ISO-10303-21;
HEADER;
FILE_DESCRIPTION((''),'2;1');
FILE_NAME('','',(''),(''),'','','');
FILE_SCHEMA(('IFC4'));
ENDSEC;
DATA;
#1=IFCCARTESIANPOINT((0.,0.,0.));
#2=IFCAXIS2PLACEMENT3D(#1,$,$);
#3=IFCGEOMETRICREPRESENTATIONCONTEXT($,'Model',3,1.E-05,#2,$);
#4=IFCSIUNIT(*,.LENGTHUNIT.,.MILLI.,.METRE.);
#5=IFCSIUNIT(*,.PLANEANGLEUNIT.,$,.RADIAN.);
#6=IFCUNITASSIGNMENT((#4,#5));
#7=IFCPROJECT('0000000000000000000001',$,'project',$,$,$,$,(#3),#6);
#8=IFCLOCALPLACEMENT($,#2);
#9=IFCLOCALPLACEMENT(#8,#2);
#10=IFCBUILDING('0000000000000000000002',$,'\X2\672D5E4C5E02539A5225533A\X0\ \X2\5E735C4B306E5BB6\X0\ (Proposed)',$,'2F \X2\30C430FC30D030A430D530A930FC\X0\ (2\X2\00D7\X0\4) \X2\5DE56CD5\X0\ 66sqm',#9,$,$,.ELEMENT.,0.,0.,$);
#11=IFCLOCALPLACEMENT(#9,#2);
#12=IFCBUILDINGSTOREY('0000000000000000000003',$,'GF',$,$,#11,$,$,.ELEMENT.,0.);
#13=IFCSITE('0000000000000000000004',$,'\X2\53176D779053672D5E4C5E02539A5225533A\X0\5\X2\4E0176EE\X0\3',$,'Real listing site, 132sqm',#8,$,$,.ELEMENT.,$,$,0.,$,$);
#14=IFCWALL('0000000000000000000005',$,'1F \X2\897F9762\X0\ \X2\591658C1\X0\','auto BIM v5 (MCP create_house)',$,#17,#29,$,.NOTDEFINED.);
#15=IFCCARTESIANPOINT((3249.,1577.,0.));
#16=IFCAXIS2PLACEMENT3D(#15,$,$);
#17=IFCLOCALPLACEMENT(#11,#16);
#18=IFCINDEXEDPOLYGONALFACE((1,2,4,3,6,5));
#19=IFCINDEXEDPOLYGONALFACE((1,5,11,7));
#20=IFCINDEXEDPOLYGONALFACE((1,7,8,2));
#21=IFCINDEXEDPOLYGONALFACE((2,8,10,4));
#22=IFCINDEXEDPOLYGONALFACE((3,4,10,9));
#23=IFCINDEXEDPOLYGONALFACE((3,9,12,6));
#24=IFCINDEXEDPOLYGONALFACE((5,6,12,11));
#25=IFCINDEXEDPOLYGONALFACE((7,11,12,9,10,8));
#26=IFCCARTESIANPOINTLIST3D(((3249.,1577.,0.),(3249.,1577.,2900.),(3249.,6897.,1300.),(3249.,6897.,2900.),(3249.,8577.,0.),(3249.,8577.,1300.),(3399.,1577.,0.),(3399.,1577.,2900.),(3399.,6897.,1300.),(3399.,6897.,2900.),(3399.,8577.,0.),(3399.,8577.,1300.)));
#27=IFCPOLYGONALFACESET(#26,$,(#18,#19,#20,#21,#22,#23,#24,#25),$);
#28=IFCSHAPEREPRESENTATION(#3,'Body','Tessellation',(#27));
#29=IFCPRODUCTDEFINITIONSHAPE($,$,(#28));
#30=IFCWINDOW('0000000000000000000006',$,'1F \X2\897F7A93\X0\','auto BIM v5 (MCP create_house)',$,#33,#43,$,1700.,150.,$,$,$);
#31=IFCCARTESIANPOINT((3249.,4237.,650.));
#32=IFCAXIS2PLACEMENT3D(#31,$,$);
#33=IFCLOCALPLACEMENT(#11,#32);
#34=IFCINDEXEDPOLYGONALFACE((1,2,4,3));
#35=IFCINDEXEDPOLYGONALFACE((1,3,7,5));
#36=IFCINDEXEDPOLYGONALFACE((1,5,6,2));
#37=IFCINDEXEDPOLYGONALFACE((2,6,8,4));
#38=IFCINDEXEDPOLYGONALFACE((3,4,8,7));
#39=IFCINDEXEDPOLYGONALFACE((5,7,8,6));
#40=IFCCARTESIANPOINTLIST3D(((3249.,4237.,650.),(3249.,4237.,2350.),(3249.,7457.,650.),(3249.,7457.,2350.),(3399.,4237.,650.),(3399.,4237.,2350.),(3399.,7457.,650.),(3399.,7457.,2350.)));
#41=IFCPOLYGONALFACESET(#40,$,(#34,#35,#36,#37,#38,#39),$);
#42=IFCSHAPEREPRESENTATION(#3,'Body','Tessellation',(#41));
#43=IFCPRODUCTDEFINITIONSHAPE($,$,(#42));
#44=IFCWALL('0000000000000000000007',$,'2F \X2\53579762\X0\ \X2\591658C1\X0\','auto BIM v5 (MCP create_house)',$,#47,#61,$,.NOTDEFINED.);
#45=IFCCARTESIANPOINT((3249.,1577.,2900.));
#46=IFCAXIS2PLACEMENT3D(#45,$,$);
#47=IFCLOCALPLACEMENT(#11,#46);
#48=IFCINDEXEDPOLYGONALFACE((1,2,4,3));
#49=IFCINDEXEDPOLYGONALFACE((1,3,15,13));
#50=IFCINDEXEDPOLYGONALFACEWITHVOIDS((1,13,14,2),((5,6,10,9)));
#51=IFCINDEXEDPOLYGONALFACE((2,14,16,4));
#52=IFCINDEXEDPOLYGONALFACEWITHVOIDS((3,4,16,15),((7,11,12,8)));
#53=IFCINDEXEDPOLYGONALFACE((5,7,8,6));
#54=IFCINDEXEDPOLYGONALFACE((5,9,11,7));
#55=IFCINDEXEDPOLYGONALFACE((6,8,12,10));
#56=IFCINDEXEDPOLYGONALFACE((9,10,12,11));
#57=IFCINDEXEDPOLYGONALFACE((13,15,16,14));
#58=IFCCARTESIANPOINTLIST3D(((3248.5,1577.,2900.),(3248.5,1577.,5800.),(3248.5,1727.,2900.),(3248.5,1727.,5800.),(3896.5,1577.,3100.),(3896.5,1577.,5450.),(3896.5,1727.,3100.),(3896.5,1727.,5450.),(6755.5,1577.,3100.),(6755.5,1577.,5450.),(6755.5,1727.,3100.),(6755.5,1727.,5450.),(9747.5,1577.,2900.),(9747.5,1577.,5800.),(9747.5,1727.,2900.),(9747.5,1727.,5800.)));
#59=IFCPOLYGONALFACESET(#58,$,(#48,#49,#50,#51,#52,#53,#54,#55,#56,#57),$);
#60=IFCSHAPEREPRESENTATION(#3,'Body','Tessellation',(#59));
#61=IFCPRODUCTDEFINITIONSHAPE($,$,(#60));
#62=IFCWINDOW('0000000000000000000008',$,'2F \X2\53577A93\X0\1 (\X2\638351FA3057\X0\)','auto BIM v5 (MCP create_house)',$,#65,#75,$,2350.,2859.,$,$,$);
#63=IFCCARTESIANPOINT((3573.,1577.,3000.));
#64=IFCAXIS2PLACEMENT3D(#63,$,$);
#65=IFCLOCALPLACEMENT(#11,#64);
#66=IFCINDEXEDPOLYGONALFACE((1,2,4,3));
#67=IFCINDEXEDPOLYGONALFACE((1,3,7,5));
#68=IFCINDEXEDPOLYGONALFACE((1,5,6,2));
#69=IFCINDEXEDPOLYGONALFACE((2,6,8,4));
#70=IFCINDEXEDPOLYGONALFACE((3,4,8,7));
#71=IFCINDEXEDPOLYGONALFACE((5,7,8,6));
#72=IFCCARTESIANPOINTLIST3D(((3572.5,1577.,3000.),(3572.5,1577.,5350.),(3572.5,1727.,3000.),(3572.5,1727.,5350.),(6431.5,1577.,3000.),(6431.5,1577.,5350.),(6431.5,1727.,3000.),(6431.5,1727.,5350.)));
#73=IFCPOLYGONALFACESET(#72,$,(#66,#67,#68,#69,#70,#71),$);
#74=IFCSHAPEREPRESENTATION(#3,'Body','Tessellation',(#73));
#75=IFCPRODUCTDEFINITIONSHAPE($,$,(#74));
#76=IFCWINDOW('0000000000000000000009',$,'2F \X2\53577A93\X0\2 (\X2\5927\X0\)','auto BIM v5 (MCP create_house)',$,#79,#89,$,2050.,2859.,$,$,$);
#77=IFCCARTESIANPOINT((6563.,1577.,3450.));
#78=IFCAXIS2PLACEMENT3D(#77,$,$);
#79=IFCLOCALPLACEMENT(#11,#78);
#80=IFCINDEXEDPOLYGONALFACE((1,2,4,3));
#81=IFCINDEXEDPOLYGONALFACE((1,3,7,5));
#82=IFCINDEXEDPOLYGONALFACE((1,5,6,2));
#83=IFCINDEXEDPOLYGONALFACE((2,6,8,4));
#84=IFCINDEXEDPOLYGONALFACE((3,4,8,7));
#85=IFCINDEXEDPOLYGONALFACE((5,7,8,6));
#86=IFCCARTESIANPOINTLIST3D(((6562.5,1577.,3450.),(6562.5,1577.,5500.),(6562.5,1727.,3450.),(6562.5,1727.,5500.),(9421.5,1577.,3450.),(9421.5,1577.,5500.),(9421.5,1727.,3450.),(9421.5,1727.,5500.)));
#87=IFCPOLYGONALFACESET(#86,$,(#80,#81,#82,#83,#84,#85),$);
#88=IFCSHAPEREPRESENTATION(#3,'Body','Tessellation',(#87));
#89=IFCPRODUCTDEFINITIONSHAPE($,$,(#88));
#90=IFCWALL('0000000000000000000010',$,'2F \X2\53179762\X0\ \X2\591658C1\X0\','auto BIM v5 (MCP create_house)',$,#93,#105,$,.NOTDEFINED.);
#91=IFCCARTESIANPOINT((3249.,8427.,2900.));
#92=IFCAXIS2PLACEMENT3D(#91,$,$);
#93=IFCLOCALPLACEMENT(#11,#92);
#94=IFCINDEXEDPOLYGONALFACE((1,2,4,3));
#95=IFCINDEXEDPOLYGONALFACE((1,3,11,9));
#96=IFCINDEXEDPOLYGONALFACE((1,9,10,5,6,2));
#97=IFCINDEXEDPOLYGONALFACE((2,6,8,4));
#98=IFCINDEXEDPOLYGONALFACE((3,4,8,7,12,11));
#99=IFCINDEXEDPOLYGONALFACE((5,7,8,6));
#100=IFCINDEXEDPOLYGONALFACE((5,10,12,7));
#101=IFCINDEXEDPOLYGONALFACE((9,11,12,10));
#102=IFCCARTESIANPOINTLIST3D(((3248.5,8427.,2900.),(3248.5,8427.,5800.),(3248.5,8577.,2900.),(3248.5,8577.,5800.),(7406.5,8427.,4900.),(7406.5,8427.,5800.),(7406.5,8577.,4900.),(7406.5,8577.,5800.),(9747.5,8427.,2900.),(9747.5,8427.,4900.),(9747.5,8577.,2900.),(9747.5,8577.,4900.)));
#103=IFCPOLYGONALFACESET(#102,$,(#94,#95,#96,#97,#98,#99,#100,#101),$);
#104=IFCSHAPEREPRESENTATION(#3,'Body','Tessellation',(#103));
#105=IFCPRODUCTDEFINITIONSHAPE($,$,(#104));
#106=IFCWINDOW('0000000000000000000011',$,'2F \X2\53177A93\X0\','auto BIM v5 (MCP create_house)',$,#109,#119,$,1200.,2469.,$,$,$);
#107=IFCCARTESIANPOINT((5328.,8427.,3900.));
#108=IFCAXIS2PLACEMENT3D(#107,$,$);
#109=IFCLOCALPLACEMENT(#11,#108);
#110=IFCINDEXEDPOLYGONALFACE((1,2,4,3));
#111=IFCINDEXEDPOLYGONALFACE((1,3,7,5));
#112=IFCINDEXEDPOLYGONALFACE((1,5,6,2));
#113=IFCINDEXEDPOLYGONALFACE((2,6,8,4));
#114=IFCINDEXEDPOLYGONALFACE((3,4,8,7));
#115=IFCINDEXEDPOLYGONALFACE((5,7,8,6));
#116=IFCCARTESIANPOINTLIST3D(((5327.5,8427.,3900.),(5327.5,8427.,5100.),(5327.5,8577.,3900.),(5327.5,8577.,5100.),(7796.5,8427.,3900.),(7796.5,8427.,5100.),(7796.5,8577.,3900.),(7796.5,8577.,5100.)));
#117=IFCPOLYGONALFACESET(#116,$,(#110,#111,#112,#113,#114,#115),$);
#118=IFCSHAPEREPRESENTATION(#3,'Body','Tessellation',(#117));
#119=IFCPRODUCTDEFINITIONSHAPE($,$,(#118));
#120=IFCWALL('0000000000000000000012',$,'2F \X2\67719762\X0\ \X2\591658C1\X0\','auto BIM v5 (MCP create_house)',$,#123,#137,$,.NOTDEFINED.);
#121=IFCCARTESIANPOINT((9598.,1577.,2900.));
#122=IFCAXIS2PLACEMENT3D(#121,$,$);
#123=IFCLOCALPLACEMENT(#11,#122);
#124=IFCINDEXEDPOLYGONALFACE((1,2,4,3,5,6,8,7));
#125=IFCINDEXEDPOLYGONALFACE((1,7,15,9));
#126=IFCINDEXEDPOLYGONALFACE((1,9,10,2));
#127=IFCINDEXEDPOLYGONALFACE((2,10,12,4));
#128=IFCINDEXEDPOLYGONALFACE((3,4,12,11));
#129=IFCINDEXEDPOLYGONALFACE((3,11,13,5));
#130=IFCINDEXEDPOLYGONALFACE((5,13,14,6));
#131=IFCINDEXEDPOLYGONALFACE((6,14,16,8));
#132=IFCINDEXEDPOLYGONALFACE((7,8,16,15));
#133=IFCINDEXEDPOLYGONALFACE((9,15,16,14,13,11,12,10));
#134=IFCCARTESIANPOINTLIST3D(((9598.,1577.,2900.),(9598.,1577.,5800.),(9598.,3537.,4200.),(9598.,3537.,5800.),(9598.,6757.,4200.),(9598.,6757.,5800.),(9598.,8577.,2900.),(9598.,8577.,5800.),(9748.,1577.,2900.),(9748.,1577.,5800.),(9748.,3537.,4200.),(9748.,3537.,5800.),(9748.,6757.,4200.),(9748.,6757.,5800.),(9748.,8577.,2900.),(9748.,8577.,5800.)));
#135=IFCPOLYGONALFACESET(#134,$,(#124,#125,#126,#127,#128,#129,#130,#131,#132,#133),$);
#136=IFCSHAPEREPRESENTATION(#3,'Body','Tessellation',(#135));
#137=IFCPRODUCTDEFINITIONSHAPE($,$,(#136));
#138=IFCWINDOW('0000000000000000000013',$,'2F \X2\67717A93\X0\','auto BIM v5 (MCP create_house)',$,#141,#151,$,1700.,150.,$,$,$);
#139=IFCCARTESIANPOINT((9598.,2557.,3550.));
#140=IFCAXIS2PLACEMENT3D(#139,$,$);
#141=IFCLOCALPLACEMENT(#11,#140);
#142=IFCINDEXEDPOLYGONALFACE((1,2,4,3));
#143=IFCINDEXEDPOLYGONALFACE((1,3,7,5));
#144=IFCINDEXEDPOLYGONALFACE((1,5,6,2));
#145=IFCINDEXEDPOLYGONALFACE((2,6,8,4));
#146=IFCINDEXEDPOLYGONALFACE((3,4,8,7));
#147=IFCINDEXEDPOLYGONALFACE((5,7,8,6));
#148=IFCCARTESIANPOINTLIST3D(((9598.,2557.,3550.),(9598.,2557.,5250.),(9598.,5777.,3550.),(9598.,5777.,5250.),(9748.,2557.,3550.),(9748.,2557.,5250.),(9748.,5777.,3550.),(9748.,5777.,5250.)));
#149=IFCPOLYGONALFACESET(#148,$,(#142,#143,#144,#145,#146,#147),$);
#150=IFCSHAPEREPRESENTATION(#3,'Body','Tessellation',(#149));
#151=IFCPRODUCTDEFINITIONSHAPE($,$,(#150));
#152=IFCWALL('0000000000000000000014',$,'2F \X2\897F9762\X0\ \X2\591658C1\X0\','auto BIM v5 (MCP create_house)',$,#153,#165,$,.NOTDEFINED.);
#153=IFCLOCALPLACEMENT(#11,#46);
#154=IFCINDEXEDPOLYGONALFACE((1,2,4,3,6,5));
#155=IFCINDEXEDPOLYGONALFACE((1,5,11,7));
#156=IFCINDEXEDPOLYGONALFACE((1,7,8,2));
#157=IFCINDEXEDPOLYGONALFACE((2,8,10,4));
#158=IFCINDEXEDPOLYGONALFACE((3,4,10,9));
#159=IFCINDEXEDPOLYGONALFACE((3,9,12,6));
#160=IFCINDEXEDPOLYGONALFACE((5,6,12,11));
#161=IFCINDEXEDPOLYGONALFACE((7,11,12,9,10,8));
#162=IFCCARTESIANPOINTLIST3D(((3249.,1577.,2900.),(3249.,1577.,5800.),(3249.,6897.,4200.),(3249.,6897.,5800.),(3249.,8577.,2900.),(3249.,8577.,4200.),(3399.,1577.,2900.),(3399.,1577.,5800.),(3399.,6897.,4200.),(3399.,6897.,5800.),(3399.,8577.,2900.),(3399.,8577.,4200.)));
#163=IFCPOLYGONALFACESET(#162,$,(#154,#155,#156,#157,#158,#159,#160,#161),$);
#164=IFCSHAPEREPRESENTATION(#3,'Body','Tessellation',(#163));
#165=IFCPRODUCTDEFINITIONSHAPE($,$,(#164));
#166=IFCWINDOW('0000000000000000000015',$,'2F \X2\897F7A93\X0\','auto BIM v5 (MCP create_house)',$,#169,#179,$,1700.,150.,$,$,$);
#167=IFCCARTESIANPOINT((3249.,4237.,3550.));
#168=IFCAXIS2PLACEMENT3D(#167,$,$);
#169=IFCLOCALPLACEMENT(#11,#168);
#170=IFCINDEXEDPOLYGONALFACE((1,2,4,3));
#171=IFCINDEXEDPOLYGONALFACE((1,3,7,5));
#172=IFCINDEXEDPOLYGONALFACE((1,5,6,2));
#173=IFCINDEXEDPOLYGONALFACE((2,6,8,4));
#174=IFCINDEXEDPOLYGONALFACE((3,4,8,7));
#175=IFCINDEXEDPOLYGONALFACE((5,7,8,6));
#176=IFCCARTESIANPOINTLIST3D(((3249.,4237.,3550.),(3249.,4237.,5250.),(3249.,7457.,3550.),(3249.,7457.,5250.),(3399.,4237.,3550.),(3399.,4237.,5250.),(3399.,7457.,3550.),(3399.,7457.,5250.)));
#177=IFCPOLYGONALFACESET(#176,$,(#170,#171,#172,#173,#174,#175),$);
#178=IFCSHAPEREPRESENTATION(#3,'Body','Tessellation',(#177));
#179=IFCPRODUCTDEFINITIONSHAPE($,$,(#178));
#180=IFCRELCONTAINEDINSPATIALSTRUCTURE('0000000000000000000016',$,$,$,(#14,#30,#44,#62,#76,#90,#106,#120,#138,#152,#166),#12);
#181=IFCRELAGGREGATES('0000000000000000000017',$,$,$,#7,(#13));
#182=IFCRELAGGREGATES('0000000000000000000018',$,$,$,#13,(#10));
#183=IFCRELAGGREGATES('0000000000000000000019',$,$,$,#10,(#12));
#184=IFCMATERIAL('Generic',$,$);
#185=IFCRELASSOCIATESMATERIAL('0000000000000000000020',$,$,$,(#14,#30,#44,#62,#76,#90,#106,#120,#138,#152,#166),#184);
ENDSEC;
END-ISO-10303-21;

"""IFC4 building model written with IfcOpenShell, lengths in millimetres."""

from ifc_helpers import new_model, si_unit, frame, frame_2d, origin, place, context, project, spatial, rectangle, extrude, material, element, fill, save


model = new_model("IFC4")

# Units and contexts
model_context = context("Model", 3, precision=1e-05, world=origin())
ifc_project = project(units=[si_unit("LENGTHUNIT", "METRE", prefix="MILLI"), si_unit("PLANEANGLEUNIT", "RADIAN")], contexts=[model_context])

# Site, building, storey
site_placement = place(None, origin())
site = spatial("IfcSite", under=ifc_project, at=site_placement, Name="北海道札幌市厚別区5丁目3", ObjectType="Real listing site, 132sqm", CompositionType="ELEMENT", RefElevation=0.0)
building_placement = place(site_placement, origin())
building = spatial("IfcBuilding", under=site, at=building_placement, Name="札幌市厚別区 平屋の家 (Proposed)", ObjectType="2F ツーバイフォー (2×4) 工法 66sqm", CompositionType="ELEMENT", ElevationOfRefHeight=0.0, ElevationOfTerrain=0.0)
storey_placement = place(building_placement, origin())
storey = spatial("IfcBuildingStorey", under=building, at=storey_placement, Name="GF", CompositionType="ELEMENT", Elevation=0.0)

# Shared definitions
ifc_material = material(Name="Generic")

# Wall, opening, window
wall_1_placement = place(storey_placement, frame((3249.0, 1577.0, 0.0)))
wall_1 = element("IfcWall", 1, at=wall_1_placement, inside=storey, material=ifc_material, Name="1F 西面 外壁", Description="auto BIM v5 (MCP create_house)", PredefinedType="NOTDEFINED", context=model_context, shape_type="SweptSolid", body=[
    extrude(rectangle(XDim=150.0, YDim=7000.0, at=frame_2d((75.0, 3500.0))), frame((3249.0, 1577.0, 0.0)), (0.0, 0.0, 1.0), 2900.0),
])
opening_1_placement = place(storey_placement, frame((3249.0, 4237.0, 650.0)))
opening_1 = element("IfcOpeningElement", 2, at=opening_1_placement, cuts=wall_1, PredefinedType="NOTDEFINED", context=model_context, shape_type="SweptSolid", body=[
    extrude(rectangle(XDim=150.0, YDim=3220.0, at=frame_2d((75.0, 1610.0))), frame((3249.0, 4237.0, 650.0)), (0.0, 0.0, 1.0), 1700.0),
])
window_1_placement = place(storey_placement, frame((3249.0, 4237.0, 650.0)))
window_1 = element("IfcWindow", 3, at=window_1_placement, inside=storey, material=ifc_material, Name="1F 西窓", Description="auto BIM v5 (MCP create_house)", OverallHeight=1700.0, OverallWidth=150.0, context=model_context, shape_type="SweptSolid", body=[
    extrude(rectangle(XDim=150.0, YDim=3220.0, at=frame_2d((75.0, 1610.0))), frame((3249.0, 4237.0, 650.0)), (0.0, 0.0, 1.0), 1700.0),
])
fill(opening_1, window_1)

# Wall, openings, windows
wall_2_placement = place(storey_placement, frame((3249.0, 1577.0, 2900.0)))
wall_2 = element("IfcWall", 4, at=wall_2_placement, inside=storey, material=ifc_material, Name="2F 南面 外壁", Description="auto BIM v5 (MCP create_house)", PredefinedType="NOTDEFINED", context=model_context, shape_type="SweptSolid", body=[
    extrude(rectangle(XDim=6499.0, YDim=150.0, at=frame_2d((3249.0, 75.0))), frame((3249.0, 1577.0, 2900.0)), (0.0, 0.0, 1.0), 2900.0),
])
opening_2_placement = place(storey_placement, frame((3573.0, 1577.0, 3000.0)))
opening_2 = element("IfcOpeningElement", 5, at=opening_2_placement, cuts=wall_2, PredefinedType="NOTDEFINED", context=model_context, shape_type="SweptSolid", body=[
    extrude(rectangle(XDim=2859.0, YDim=150.0, at=frame_2d((1429.0, 75.0))), frame((3573.0, 1577.0, 3000.0)), (0.0, 0.0, 1.0), 2350.0),
])
opening_3_placement = place(storey_placement, frame((6563.0, 1577.0, 3450.0)))
opening_3 = element("IfcOpeningElement", 6, at=opening_3_placement, cuts=wall_2, PredefinedType="NOTDEFINED", context=model_context, shape_type="SweptSolid", body=[
    extrude(rectangle(XDim=2859.0, YDim=150.0, at=frame_2d((1429.0, 75.0))), frame((6563.0, 1577.0, 3450.0)), (0.0, 0.0, 1.0), 2050.0),
])
window_2_placement = place(storey_placement, frame((3573.0, 1577.0, 3000.0)))
window_2 = element("IfcWindow", 7, at=window_2_placement, inside=storey, material=ifc_material, Name="2F 南窓1 (掃出し)", Description="auto BIM v5 (MCP create_house)", OverallHeight=2350.0, OverallWidth=2859.0, context=model_context, shape_type="SweptSolid", body=[
    extrude(rectangle(XDim=2859.0, YDim=150.0, at=frame_2d((1429.0, 75.0))), frame((3573.0, 1577.0, 3000.0)), (0.0, 0.0, 1.0), 2350.0),
])
fill(opening_2, window_2)
window_3_placement = place(storey_placement, frame((6563.0, 1577.0, 3450.0)))
window_3 = element("IfcWindow", 8, at=window_3_placement, inside=storey, material=ifc_material, Name="2F 南窓2 (大)", Description="auto BIM v5 (MCP create_house)", OverallHeight=2050.0, OverallWidth=2859.0, context=model_context, shape_type="SweptSolid", body=[
    extrude(rectangle(XDim=2859.0, YDim=150.0, at=frame_2d((1429.0, 75.0))), frame((6563.0, 1577.0, 3450.0)), (0.0, 0.0, 1.0), 2050.0),
])
fill(opening_3, window_3)

# Walls, openings, windows
wall_3_placement = place(storey_placement, frame((3249.0, 8427.0, 2900.0)))
wall_3 = element("IfcWall", 9, at=wall_3_placement, inside=storey, material=ifc_material, Name="2F 北面 外壁", Description="auto BIM v5 (MCP create_house)", PredefinedType="NOTDEFINED", context=model_context, shape_type="SweptSolid", body=[
    extrude(rectangle(XDim=6499.0, YDim=150.0, at=frame_2d((3249.0, 75.0))), frame((3249.0, 8427.0, 2900.0)), (0.0, 0.0, 1.0), 2900.0),
])
opening_4_placement = place(storey_placement, frame((5328.0, 8427.0, 3900.0)))
opening_4 = element("IfcOpeningElement", 10, at=opening_4_placement, cuts=wall_3, PredefinedType="NOTDEFINED", context=model_context, shape_type="SweptSolid", body=[
    extrude(rectangle(XDim=2469.0, YDim=150.0, at=frame_2d((1234.0, 75.0))), frame((5328.0, 8427.0, 3900.0)), (0.0, 0.0, 1.0), 1200.0),
])
window_4_placement = place(storey_placement, frame((5328.0, 8427.0, 3900.0)))
window_4 = element("IfcWindow", 11, at=window_4_placement, inside=storey, material=ifc_material, Name="2F 北窓", Description="auto BIM v5 (MCP create_house)", OverallHeight=1200.0, OverallWidth=2469.0, context=model_context, shape_type="SweptSolid", body=[
    extrude(rectangle(XDim=2469.0, YDim=150.0, at=frame_2d((1234.0, 75.0))), frame((5328.0, 8427.0, 3900.0)), (0.0, 0.0, 1.0), 1200.0),
])
fill(opening_4, window_4)
wall_4_placement = place(storey_placement, frame((9598.0, 1577.0, 2900.0)))
wall_4 = element("IfcWall", 12, at=wall_4_placement, inside=storey, material=ifc_material, Name="2F 東面 外壁", Description="auto BIM v5 (MCP create_house)", PredefinedType="NOTDEFINED", context=model_context, shape_type="SweptSolid", body=[
    extrude(rectangle(XDim=150.0, YDim=7000.0, at=frame_2d((75.0, 3500.0))), frame((9598.0, 1577.0, 2900.0)), (0.0, 0.0, 1.0), 2900.0),
])
opening_5_placement = place(storey_placement, frame((9598.0, 2557.0, 3550.0)))
opening_5 = element("IfcOpeningElement", 13, at=opening_5_placement, cuts=wall_4, PredefinedType="NOTDEFINED", context=model_context, shape_type="SweptSolid", body=[
    extrude(rectangle(XDim=150.0, YDim=3220.0, at=frame_2d((75.0, 1610.0))), frame((9598.0, 2557.0, 3550.0)), (0.0, 0.0, 1.0), 1700.0),
])
window_5_placement = place(storey_placement, frame((9598.0, 2557.0, 3550.0)))
window_5 = element("IfcWindow", 14, at=window_5_placement, inside=storey, material=ifc_material, Name="2F 東窓", Description="auto BIM v5 (MCP create_house)", OverallHeight=1700.0, OverallWidth=150.0, context=model_context, shape_type="SweptSolid", body=[
    extrude(rectangle(XDim=150.0, YDim=3220.0, at=frame_2d((75.0, 1610.0))), frame((9598.0, 2557.0, 3550.0)), (0.0, 0.0, 1.0), 1700.0),
])
fill(opening_5, window_5)
wall_5_placement = place(storey_placement, frame((3249.0, 1577.0, 2900.0)))
wall_5 = element("IfcWall", 15, at=wall_5_placement, inside=storey, material=ifc_material, Name="2F 西面 外壁", Description="auto BIM v5 (MCP create_house)", PredefinedType="NOTDEFINED", context=model_context, shape_type="SweptSolid", body=[
    extrude(rectangle(XDim=150.0, YDim=7000.0, at=frame_2d((75.0, 3500.0))), frame((3249.0, 1577.0, 2900.0)), (0.0, 0.0, 1.0), 2900.0),
])
opening_6_placement = place(storey_placement, frame((3249.0, 4237.0, 3550.0)))
opening_6 = element("IfcOpeningElement", 16, at=opening_6_placement, cuts=wall_5, PredefinedType="NOTDEFINED", context=model_context, shape_type="SweptSolid", body=[
    extrude(rectangle(XDim=150.0, YDim=3220.0, at=frame_2d((75.0, 1610.0))), frame((3249.0, 4237.0, 3550.0)), (0.0, 0.0, 1.0), 1700.0),
])
window_6_placement = place(storey_placement, frame((3249.0, 4237.0, 3550.0)))
window_6 = element("IfcWindow", 17, at=window_6_placement, inside=storey, material=ifc_material, Name="2F 西窓", Description="auto BIM v5 (MCP create_house)", OverallHeight=1700.0, OverallWidth=150.0, context=model_context, shape_type="SweptSolid", body=[
    extrude(rectangle(XDim=150.0, YDim=3220.0, at=frame_2d((75.0, 1610.0))), frame((3249.0, 4237.0, 3550.0)), (0.0, 0.0, 1.0), 1700.0),
])
fill(opening_6, window_6)

save(model, "model.ifc")
